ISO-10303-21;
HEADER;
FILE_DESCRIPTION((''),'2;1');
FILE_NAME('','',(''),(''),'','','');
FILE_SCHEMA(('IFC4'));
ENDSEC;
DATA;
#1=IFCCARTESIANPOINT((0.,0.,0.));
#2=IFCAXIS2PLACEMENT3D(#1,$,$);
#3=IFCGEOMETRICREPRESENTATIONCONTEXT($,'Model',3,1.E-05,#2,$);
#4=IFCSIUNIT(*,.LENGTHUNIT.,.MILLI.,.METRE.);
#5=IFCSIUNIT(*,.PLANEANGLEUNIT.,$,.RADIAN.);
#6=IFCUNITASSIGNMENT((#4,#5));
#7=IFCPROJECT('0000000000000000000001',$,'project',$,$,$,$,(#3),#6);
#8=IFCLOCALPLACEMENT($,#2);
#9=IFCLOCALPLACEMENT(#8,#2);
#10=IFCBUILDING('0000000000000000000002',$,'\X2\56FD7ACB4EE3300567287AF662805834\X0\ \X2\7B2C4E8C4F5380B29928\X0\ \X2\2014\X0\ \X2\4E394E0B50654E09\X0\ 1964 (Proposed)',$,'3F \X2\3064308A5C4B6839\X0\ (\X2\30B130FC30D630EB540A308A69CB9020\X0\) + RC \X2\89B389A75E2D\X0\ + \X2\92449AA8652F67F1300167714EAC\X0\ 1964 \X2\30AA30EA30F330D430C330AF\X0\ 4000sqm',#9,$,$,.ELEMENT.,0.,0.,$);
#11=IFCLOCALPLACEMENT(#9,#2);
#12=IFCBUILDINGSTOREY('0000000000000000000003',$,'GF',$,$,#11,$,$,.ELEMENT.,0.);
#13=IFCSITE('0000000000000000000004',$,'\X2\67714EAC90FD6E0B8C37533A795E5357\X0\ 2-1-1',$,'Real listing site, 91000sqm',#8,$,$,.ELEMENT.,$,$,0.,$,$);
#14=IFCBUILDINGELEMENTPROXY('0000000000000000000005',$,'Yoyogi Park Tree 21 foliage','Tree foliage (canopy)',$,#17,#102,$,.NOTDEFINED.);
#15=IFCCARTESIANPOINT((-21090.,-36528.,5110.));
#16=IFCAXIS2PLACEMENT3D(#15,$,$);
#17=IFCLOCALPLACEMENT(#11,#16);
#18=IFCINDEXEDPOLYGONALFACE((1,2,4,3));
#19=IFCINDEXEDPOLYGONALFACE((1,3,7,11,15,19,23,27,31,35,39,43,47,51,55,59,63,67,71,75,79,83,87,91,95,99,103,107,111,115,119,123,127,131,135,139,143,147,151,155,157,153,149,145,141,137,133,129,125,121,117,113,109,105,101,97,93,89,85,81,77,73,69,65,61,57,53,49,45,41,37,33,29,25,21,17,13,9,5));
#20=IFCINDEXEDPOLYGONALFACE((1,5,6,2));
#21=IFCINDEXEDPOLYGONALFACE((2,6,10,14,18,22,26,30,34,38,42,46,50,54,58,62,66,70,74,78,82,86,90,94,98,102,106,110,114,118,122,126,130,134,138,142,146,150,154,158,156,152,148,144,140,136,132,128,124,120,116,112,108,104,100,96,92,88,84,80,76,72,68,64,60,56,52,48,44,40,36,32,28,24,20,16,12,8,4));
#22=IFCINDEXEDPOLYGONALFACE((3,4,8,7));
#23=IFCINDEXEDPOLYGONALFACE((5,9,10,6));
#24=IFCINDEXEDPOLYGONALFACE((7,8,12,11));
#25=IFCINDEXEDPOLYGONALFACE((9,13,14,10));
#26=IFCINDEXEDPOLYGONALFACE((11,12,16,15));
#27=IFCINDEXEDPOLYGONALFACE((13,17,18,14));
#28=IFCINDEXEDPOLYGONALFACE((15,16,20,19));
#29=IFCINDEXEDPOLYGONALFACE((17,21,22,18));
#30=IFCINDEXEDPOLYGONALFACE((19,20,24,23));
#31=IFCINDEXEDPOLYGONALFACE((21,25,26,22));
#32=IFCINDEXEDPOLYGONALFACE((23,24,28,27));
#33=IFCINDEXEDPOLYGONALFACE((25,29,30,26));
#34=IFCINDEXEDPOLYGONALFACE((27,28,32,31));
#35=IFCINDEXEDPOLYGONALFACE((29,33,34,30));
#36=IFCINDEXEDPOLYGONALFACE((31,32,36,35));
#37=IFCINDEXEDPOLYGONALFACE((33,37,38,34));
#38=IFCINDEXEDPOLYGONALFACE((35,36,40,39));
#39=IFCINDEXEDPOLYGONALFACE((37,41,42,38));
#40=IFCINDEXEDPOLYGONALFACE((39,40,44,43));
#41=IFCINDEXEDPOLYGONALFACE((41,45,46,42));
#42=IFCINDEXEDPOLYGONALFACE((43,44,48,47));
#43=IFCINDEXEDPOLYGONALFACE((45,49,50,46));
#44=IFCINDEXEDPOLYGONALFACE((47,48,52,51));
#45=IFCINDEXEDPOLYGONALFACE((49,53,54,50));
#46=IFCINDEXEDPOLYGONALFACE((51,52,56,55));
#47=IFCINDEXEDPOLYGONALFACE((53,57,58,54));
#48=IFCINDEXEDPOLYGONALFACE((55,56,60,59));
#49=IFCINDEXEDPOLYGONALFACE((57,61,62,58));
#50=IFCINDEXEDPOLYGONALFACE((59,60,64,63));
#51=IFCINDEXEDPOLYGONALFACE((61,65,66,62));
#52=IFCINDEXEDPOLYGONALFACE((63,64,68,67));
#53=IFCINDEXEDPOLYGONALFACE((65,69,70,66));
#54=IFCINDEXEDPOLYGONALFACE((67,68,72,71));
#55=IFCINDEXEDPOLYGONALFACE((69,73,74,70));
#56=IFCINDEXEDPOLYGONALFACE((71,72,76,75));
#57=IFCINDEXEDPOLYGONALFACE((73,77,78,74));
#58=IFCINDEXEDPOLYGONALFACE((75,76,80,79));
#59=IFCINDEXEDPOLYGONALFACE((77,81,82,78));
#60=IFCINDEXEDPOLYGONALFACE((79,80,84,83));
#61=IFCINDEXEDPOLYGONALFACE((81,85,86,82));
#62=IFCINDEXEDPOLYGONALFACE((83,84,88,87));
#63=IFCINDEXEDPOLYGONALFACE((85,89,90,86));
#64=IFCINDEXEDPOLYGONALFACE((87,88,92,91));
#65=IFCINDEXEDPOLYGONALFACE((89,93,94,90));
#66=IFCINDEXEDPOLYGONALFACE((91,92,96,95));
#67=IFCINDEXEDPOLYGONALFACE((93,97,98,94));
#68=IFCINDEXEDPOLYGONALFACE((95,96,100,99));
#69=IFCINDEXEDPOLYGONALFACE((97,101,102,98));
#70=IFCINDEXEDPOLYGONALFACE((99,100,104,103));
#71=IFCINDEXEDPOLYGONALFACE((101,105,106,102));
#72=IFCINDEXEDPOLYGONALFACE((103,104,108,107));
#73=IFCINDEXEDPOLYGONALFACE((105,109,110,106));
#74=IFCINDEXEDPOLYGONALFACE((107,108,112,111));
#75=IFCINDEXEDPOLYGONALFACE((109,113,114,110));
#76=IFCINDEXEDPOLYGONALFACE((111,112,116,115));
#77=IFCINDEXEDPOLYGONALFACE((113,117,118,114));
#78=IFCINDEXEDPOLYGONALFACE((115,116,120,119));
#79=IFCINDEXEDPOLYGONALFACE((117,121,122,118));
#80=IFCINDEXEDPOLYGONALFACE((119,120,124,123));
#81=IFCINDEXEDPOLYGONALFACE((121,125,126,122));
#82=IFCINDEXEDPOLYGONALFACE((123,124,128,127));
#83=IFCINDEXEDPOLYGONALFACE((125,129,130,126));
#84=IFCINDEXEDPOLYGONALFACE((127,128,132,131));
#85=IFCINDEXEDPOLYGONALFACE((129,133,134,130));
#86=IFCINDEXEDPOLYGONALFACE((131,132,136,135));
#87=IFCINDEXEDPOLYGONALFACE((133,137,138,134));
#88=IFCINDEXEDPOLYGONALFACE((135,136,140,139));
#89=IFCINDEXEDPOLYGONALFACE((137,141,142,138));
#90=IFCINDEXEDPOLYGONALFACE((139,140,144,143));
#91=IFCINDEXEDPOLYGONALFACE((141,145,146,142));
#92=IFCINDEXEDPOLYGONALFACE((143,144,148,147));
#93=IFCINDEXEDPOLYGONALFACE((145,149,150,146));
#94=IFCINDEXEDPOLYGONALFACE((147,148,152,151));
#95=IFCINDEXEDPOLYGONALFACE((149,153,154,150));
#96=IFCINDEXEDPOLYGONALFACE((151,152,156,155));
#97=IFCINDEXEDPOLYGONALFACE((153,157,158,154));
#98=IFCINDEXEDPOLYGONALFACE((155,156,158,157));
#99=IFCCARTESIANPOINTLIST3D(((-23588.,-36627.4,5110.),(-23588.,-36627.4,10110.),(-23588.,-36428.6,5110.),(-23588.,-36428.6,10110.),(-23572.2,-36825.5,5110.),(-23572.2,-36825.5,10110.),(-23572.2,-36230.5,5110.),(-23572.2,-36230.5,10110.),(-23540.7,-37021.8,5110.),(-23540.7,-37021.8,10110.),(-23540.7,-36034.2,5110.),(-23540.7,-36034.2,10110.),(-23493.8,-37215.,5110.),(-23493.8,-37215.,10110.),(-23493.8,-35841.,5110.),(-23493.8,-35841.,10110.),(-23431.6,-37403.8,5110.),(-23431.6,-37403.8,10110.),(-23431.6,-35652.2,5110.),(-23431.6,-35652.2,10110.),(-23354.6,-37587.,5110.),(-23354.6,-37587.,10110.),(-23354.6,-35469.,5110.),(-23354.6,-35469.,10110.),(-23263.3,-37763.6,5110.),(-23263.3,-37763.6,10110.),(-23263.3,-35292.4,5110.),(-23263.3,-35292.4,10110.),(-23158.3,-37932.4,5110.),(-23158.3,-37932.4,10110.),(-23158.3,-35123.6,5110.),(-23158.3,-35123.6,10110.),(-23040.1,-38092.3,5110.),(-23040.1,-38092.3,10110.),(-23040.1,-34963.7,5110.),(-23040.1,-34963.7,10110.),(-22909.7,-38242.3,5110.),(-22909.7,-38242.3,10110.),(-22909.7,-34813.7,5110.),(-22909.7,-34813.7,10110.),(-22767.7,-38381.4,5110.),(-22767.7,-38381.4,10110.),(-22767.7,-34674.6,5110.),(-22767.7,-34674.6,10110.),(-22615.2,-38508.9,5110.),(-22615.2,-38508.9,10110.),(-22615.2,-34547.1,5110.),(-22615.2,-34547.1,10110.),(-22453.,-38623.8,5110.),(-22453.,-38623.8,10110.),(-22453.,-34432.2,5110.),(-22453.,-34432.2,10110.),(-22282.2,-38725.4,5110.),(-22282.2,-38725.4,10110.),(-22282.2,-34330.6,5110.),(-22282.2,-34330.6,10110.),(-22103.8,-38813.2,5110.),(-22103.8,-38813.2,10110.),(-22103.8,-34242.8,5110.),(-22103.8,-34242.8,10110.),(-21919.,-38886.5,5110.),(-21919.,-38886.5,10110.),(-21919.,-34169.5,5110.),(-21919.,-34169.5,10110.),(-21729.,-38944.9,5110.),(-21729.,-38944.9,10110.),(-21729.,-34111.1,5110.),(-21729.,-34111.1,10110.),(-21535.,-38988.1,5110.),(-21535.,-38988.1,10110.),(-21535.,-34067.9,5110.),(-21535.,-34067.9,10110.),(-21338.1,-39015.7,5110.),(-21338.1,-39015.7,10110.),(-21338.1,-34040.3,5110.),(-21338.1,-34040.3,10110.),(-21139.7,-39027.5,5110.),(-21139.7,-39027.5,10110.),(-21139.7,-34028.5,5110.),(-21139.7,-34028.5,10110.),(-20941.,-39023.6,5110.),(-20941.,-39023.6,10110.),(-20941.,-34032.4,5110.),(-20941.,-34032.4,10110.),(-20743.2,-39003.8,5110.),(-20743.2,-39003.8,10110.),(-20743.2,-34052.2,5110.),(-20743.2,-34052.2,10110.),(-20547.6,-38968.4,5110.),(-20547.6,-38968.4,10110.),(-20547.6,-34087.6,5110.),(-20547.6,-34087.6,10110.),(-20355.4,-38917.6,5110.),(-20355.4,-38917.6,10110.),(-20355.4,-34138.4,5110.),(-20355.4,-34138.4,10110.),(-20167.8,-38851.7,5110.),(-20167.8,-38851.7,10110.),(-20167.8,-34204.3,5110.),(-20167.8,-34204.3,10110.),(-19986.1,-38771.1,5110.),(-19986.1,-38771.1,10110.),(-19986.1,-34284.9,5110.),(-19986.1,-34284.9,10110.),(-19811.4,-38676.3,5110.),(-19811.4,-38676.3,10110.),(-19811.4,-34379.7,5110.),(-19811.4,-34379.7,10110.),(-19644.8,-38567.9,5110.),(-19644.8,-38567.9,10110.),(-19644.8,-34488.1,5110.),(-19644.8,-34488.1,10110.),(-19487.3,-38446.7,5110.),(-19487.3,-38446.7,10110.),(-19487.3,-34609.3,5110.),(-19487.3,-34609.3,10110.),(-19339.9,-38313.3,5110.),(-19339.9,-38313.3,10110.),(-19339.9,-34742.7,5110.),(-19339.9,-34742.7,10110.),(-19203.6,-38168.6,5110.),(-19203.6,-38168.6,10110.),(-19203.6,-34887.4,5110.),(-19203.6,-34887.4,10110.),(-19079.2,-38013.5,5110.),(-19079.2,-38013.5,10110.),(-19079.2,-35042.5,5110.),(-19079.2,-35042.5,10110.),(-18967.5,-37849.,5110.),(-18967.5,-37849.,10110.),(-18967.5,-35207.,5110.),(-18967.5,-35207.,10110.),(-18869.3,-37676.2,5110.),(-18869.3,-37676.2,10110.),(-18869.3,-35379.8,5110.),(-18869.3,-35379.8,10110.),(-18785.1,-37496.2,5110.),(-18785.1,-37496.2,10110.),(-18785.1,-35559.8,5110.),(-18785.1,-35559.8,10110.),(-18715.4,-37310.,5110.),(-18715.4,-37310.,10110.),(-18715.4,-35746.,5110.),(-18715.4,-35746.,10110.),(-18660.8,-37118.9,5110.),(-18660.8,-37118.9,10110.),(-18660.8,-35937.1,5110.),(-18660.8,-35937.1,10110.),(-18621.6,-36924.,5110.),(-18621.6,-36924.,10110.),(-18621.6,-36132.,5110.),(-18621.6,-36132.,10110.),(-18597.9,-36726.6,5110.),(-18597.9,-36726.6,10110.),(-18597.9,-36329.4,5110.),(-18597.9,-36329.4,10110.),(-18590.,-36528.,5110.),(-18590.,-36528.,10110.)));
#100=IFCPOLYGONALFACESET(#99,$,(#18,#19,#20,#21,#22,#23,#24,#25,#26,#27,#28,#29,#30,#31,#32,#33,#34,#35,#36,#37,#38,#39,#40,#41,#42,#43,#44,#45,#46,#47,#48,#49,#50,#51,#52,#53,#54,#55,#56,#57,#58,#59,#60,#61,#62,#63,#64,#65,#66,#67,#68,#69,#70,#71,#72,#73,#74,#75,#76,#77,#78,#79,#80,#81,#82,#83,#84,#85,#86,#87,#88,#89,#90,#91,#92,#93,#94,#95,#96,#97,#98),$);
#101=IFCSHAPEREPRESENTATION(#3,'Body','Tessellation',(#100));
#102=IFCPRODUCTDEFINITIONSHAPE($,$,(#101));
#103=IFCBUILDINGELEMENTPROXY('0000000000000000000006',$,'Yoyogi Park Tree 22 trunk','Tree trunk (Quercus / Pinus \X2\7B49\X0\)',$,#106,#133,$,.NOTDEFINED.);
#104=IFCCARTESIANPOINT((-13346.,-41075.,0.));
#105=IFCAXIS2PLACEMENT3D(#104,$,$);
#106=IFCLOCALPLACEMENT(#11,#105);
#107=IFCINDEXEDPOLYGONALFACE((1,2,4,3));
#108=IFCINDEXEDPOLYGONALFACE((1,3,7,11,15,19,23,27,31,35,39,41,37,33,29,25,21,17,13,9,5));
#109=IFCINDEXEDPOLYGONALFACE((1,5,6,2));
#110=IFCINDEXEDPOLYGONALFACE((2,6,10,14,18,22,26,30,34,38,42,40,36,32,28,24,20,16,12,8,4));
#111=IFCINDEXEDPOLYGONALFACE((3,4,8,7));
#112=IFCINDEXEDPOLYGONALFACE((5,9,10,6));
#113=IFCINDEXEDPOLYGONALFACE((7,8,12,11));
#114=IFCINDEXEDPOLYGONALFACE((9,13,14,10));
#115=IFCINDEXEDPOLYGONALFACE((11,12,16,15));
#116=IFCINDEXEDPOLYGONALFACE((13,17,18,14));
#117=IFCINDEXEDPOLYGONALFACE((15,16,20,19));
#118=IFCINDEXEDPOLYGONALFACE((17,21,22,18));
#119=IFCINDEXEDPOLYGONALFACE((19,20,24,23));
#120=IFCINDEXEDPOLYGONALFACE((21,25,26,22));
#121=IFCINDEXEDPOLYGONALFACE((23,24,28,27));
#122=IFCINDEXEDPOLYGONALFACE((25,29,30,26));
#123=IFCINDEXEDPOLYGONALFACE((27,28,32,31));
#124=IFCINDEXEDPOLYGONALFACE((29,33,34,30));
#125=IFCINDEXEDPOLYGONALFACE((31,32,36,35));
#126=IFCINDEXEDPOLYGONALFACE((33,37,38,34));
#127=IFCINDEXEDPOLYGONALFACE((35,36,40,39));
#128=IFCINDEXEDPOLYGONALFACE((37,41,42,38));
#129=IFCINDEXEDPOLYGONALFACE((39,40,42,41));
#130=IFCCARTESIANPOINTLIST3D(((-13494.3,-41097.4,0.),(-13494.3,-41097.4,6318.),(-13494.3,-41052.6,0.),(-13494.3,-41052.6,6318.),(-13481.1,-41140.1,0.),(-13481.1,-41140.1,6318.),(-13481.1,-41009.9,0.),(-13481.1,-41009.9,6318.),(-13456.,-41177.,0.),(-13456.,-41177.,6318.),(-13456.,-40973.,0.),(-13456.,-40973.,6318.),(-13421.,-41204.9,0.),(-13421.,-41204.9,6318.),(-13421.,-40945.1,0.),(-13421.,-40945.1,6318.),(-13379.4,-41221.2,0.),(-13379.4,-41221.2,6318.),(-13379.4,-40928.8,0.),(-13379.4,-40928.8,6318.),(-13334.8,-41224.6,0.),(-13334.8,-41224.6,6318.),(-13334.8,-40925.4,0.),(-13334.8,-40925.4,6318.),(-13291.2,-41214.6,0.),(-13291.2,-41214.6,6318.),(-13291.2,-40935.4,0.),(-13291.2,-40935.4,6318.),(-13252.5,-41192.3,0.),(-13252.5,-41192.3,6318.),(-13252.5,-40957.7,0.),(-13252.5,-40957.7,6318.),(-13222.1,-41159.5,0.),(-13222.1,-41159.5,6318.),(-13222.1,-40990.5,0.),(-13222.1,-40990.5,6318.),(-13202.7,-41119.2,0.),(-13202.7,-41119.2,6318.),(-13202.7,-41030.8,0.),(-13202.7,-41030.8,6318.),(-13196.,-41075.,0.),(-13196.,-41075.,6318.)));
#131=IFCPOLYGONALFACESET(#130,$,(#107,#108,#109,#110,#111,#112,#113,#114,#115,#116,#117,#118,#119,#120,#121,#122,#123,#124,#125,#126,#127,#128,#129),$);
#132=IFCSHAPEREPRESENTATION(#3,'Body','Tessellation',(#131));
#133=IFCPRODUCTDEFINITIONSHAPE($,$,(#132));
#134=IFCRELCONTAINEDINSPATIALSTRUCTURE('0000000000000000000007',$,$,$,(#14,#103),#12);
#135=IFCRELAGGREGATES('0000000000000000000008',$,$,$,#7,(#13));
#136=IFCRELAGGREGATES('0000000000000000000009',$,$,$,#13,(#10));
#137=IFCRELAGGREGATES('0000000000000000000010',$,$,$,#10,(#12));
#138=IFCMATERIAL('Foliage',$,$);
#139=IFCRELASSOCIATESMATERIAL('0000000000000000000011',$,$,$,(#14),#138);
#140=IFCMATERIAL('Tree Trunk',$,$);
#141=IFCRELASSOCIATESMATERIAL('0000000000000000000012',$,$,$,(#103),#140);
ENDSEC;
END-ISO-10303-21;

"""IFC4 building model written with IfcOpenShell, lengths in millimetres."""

from ifc_helpers import new_model, si_unit, frame, origin, origin_2d, place, context, project, spatial, circle, extrude, material, element, save


model = new_model("IFC4")

# Units and contexts
model_context = context("Model", 3, precision=1e-05, world=origin())
ifc_project = project(units=[si_unit("LENGTHUNIT", "METRE", prefix="MILLI"), si_unit("PLANEANGLEUNIT", "RADIAN")], contexts=[model_context])

# Site, building, storey
site_placement = place(None, origin())
site = spatial("IfcSite", under=ifc_project, at=site_placement, Name="東京都渋谷区神南 2-1-1", ObjectType="Real listing site, 91000sqm", CompositionType="ELEMENT", RefElevation=0.0)
building_placement = place(site_placement, origin())
building = spatial("IfcBuilding", under=site, at=building_placement, Name="国立代々木競技場 第二体育館 — 丹下健三 1964 (Proposed)", ObjectType="3F つり屋根 (ケーブル吊り構造) + RC 観覧席 + 鉄骨支柱、東京 1964 オリンピック 4000sqm", CompositionType="ELEMENT", ElevationOfRefHeight=0.0, ElevationOfTerrain=0.0)
storey_placement = place(building_placement, origin())
storey = spatial("IfcBuildingStorey", under=building, at=storey_placement, Name="GF", CompositionType="ELEMENT", Elevation=0.0)

# Building element proxies
ifc_material_1 = material(Name="Tree Trunk")
ifc_material_2 = material(Name="Foliage")
proxy_1_placement = place(storey_placement, frame((-21090.0, -36528.0, 5110.0)))
element("IfcBuildingElementProxy", 1, at=proxy_1_placement, inside=storey, material=ifc_material_2, Name="Yoyogi Park Tree 21 foliage", Description="Tree foliage (canopy)", PredefinedType="NOTDEFINED", context=model_context, shape_type="SweptSolid", body=[
    extrude(circle(Radius=2500.0, at=origin_2d()), frame((-21090.0, -36528.0, 5110.0)), (0.0, 0.0, 1.0), 5000.0),
])
proxy_2_placement = place(storey_placement, frame((-13346.0, -41075.0, 0.0)))
element("IfcBuildingElementProxy", 2, at=proxy_2_placement, inside=storey, material=ifc_material_1, Name="Yoyogi Park Tree 22 trunk", Description="Tree trunk (Quercus / Pinus 等)", PredefinedType="NOTDEFINED", context=model_context, shape_type="SweptSolid", body=[
    extrude(circle(Radius=150.0, at=origin_2d()), frame((-13346.0, -41075.0, 0.0)), (0.0, 0.0, 1.0), 6318.0),
])

save(model, "model.ifc")
